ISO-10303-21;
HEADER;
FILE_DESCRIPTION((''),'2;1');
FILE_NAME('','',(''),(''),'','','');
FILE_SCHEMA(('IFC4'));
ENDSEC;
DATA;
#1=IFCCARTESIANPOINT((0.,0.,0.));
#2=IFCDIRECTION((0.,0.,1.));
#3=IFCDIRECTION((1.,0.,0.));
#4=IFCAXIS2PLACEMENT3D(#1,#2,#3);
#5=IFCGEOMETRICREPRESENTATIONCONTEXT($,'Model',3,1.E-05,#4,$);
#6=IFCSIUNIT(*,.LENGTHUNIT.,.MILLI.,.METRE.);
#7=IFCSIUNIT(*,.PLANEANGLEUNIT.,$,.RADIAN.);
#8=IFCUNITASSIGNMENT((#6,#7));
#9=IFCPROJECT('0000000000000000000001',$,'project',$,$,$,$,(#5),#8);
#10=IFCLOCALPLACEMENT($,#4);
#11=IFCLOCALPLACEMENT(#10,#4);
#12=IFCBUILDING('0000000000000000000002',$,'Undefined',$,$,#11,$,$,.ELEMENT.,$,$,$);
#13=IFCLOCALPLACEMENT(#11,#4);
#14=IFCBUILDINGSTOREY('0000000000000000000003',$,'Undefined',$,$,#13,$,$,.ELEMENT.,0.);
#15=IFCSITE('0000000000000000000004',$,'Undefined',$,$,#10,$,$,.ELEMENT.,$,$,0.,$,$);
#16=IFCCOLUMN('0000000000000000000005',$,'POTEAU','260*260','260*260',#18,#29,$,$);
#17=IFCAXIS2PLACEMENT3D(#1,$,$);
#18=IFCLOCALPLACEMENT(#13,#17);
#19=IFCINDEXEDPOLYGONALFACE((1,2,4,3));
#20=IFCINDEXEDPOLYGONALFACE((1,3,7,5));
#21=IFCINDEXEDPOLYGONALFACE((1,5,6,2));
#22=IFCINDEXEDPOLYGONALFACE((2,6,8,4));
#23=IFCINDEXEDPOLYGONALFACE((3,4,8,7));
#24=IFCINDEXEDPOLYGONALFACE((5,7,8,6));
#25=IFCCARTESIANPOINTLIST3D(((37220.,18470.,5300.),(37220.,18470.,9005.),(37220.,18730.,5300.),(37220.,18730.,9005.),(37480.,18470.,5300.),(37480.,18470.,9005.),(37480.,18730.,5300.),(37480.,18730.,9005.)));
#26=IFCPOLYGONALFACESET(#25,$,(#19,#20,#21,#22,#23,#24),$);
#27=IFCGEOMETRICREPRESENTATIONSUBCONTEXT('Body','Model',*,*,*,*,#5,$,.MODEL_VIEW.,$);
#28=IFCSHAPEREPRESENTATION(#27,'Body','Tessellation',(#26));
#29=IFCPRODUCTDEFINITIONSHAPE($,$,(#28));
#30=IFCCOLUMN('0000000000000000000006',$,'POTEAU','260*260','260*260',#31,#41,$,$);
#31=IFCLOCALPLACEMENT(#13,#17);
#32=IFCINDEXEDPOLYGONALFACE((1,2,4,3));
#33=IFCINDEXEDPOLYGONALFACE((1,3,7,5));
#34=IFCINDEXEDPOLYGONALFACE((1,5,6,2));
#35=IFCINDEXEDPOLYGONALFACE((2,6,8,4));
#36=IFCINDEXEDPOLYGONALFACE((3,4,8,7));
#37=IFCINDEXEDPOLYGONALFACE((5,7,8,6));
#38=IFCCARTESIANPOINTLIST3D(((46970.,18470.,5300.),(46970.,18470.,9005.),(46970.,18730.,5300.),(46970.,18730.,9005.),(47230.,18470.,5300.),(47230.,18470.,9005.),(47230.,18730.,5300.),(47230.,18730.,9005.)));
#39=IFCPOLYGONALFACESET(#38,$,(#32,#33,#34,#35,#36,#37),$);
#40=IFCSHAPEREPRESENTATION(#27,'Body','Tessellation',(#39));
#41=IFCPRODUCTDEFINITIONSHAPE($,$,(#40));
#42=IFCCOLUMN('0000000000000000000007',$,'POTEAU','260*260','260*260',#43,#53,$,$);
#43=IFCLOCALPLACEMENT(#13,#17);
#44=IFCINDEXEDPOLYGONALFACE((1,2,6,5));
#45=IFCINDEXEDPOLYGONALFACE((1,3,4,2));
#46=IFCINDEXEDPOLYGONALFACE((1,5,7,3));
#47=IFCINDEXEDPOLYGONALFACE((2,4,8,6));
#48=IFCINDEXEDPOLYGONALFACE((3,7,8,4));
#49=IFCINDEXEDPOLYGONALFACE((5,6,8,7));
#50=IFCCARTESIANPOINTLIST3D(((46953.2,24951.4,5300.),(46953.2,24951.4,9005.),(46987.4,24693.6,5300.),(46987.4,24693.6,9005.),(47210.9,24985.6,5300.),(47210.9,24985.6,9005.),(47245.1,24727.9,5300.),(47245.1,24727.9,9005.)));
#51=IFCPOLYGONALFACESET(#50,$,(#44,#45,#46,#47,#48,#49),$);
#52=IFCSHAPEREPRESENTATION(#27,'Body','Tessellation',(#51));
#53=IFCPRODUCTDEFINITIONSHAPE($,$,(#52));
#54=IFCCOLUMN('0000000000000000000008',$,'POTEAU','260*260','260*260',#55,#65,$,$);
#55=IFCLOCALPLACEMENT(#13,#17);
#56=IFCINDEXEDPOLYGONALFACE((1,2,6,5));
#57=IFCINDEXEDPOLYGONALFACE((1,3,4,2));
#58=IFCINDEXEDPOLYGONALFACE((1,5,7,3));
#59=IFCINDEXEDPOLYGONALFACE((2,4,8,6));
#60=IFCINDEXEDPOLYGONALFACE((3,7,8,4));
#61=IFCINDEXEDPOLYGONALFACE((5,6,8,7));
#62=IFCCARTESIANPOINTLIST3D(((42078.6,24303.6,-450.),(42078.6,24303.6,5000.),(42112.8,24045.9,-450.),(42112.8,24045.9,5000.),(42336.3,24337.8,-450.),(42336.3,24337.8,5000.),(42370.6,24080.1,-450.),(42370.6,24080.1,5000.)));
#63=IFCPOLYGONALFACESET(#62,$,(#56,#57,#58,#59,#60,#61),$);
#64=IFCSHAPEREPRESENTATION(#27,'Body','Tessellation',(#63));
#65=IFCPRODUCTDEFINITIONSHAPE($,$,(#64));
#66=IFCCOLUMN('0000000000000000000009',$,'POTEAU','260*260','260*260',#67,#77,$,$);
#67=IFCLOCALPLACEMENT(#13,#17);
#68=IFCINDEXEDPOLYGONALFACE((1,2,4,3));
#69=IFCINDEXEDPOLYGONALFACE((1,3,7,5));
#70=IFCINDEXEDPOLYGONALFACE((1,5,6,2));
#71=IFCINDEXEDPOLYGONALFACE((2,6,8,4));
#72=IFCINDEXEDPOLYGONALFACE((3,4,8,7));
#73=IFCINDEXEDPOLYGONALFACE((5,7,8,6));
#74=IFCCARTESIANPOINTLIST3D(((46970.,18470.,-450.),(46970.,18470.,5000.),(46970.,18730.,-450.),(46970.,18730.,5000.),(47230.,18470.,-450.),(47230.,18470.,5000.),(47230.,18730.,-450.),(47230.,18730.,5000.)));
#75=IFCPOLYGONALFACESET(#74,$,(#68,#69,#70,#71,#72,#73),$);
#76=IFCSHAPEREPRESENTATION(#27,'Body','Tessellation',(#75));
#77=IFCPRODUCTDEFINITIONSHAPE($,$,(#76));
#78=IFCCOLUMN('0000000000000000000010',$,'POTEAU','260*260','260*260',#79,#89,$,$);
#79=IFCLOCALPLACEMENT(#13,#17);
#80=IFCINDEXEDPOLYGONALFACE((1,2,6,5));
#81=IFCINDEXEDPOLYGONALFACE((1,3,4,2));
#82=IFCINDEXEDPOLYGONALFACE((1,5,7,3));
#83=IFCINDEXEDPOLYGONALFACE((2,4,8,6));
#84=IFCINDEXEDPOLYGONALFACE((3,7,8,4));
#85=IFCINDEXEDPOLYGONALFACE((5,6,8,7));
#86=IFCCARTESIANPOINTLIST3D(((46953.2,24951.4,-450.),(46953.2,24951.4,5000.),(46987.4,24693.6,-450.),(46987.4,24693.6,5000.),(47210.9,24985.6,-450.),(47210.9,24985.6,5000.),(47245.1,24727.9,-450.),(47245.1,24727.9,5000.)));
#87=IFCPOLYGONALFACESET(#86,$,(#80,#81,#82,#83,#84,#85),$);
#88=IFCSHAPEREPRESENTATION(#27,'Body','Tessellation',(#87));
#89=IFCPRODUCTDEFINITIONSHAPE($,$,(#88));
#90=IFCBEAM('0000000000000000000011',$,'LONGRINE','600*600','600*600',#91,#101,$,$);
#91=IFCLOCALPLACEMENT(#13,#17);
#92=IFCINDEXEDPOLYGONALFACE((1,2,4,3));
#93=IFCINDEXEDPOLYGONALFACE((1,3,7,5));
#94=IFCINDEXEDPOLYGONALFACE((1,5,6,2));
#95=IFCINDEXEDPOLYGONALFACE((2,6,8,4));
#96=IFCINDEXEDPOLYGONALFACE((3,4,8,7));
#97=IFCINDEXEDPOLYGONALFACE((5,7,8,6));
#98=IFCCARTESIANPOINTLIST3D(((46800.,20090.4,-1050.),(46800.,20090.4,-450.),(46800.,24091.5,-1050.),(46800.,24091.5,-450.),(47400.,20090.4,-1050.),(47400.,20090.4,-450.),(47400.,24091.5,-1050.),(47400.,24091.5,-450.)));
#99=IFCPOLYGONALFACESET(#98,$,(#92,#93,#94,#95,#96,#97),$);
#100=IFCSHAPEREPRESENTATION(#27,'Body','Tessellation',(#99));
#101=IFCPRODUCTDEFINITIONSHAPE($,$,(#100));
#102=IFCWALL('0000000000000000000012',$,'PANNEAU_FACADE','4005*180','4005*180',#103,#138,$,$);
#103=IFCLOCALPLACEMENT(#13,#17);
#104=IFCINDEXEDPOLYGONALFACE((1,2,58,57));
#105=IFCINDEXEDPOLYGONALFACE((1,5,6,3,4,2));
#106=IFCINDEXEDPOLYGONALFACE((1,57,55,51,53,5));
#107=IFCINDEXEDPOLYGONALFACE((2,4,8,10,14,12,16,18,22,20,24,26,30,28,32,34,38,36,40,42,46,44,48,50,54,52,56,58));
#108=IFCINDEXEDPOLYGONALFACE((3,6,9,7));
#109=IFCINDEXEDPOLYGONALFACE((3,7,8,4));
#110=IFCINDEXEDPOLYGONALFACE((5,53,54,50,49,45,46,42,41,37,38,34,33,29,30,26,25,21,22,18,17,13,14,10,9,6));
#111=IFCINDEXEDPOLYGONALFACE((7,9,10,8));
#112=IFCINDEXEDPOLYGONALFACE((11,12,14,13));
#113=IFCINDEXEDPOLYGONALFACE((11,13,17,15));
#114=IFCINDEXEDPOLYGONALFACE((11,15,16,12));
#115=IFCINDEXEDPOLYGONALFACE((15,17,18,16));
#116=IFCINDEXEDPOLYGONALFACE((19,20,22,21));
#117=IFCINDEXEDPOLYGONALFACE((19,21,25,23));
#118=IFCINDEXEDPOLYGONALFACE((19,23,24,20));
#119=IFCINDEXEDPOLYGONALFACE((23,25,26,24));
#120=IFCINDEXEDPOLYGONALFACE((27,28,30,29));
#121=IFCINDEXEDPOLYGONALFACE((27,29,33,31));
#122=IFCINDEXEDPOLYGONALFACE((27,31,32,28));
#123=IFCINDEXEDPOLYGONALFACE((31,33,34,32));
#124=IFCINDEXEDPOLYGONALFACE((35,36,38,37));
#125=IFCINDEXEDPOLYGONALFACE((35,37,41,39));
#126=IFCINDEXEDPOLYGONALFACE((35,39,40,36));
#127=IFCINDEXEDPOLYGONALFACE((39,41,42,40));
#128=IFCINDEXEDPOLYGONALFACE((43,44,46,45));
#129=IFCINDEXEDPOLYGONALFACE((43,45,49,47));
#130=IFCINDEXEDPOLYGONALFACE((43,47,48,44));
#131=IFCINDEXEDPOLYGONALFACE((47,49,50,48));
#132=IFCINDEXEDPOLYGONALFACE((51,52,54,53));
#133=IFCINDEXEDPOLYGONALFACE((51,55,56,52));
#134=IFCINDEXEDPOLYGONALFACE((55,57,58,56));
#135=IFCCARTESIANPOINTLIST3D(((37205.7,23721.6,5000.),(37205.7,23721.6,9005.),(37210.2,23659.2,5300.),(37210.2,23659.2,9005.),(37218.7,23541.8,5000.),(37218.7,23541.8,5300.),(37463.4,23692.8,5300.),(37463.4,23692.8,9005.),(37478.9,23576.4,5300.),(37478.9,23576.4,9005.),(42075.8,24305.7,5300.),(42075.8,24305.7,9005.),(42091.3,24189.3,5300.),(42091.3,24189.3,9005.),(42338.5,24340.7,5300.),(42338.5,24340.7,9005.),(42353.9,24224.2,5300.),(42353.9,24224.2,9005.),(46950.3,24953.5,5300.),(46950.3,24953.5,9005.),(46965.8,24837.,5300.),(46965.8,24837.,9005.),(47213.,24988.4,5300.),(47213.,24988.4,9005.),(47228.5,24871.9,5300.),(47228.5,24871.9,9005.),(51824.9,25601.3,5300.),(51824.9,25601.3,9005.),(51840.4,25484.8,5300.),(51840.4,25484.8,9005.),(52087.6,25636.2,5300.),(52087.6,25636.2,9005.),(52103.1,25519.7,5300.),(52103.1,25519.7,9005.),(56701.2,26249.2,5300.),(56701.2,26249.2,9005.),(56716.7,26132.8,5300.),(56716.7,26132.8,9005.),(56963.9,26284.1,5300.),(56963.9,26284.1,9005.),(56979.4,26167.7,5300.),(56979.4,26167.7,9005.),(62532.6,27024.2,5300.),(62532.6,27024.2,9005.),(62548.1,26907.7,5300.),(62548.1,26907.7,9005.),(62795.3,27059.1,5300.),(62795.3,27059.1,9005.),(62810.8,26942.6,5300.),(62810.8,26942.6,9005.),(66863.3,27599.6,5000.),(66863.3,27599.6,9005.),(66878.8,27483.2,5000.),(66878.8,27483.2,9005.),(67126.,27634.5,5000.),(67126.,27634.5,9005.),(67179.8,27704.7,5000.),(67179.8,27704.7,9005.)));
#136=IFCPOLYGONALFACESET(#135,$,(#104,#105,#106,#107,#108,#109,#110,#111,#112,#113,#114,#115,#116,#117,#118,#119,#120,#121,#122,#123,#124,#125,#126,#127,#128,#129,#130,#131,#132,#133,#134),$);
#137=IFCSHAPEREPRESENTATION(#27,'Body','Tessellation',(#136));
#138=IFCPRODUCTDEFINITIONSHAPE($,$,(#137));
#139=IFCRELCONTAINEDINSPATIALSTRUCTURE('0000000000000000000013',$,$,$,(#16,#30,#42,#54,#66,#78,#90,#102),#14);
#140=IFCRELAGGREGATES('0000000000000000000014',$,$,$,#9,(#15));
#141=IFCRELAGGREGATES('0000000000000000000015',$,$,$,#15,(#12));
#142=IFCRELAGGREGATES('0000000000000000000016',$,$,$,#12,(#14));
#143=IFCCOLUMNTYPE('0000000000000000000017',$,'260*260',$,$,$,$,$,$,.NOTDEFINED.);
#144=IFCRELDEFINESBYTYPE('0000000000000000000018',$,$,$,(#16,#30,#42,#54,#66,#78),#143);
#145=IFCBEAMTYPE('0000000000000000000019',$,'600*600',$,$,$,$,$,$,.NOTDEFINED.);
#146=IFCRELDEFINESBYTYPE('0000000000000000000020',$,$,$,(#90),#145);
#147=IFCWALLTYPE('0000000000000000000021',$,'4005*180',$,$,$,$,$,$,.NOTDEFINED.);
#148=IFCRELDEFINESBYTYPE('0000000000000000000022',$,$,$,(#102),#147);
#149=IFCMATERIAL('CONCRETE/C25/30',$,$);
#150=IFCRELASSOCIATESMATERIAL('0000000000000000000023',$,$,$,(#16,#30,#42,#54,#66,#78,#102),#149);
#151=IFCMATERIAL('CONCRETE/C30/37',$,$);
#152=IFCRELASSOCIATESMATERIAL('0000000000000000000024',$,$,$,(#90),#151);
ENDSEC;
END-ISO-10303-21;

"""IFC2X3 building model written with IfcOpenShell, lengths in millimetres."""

from ifc_helpers import new_model, si_unit, frame, frame_2d, origin_with_axes, origin_2d_with_axis, place, context, subcontext, project, spatial, rectangle, extrude, boolean, halfspace, material, type_object, element, save


model = new_model("IFC2X3")

# Units and contexts
model_context = context("Model", 3, precision=1e-05, world=origin_with_axes())
body_context = subcontext(model_context, "Body", "Model", "MODEL_VIEW")
ifc_project = project(units=[si_unit("LENGTHUNIT", "METRE", prefix="MILLI"), si_unit("PLANEANGLEUNIT", "RADIAN")], contexts=[model_context])

# Site, building, storey
site_placement = place(None, origin_with_axes())
site = spatial("IfcSite", under=ifc_project, at=site_placement, Name="Undefined", CompositionType="ELEMENT", RefElevation=0.0)
building_placement = place(site_placement, origin_with_axes())
building = spatial("IfcBuilding", under=site, at=building_placement, Name="Undefined", CompositionType="ELEMENT")
storey_placement = place(building_placement, origin_with_axes())
storey = spatial("IfcBuildingStorey", under=building, at=storey_placement, Name="Undefined", CompositionType="ELEMENT", Elevation=0.0)

# Columns
ifc_material_1 = material(Name="CONCRETE/C30/37")
ifc_material_2 = material(Name="CONCRETE/C25/30")
column_type_1 = type_object("IfcColumnType", Name="260*260", PredefinedType="NOTDEFINED")
for number, where, z_axis, x_axis, name in (
    (1, (37350.0, 18600.0, 5300.0), (0.0, 0.0, 1.0), (1.0, 0.0, 0.0), "POTEAU"),
    (2, (47100.0, 18600.0, 5300.0), (0.0, 0.0, 1.0), (1.0, 0.0, 0.0), "POTEAU"),
):
    element("IfcColumn", number, at=place(storey_placement, frame(where, z_axis=z_axis, x_axis=x_axis)), inside=storey, type_object=column_type_1, material=ifc_material_2, Name=name, Description="260*260", ObjectType="260*260", context=body_context, shape_type="SweptSolid", body=[
        extrude(rectangle(XDim=260.0, YDim=260.0, at=origin_2d_with_axis()), frame((0.0, 0.0, 3705.0), z_axis=(0.0, 0.0, -1.0), x_axis=(-1.0, 0.0, 0.0)), (0.0, 0.0, 1.0), 3705.0),
    ])
column_1_placement = place(storey_placement, frame((47099.1, 24839.6, 5300.0), z_axis=(0.0, 0.0, 1.0), x_axis=(1.0, 0.0, 0.0)))
element("IfcColumn", 3, at=column_1_placement, inside=storey, type_object=column_type_1, material=ifc_material_2, Name="POTEAU", Description="260*260", ObjectType="260*260", context=body_context, shape_type="SweptSolid", body=[
    extrude(rectangle(XDim=260.0, YDim=260.0, at=origin_2d_with_axis()), frame((0.0, 0.0, 3705.0), z_axis=(0.0, 0.0, -1.0), x_axis=(-0.131727, 0.991286, 0.0)), (0.0, 0.0, 1.0), 3705.0),
])
column_2_placement = place(storey_placement, frame((42224.6, 24191.9, -450.0), z_axis=(0.0, 0.0, 1.0), x_axis=(1.0, 0.0, 0.0)))
element("IfcColumn", 4, at=column_2_placement, inside=storey, type_object=column_type_1, material=ifc_material_2, Name="POTEAU", Description="260*260", ObjectType="260*260", context=body_context, shape_type="SweptSolid", body=[
    extrude(rectangle(XDim=260.0, YDim=260.0, at=origin_2d_with_axis()), frame((0.0, 0.0, 5450.0), z_axis=(0.0, 0.0, -1.0), x_axis=(-0.131727, 0.991286, 0.0)), (0.0, 0.0, 1.0), 5450.0),
])
column_3_placement = place(storey_placement, frame((47100.0, 18600.0, -450.0), z_axis=(0.0, 0.0, 1.0), x_axis=(1.0, 0.0, 0.0)))
element("IfcColumn", 5, at=column_3_placement, inside=storey, type_object=column_type_1, material=ifc_material_2, Name="POTEAU", Description="260*260", ObjectType="260*260", context=body_context, shape_type="SweptSolid", body=[
    extrude(rectangle(XDim=260.0, YDim=260.0, at=origin_2d_with_axis()), frame((0.0, 0.0, 5450.0), z_axis=(0.0, 0.0, -1.0), x_axis=(-1.0, 0.0, 0.0)), (0.0, 0.0, 1.0), 5450.0),
])
column_4_placement = place(storey_placement, frame((47099.1, 24839.6, -450.0), z_axis=(0.0, 0.0, 1.0), x_axis=(1.0, 0.0, 0.0)))
element("IfcColumn", 6, at=column_4_placement, inside=storey, type_object=column_type_1, material=ifc_material_2, Name="POTEAU", Description="260*260", ObjectType="260*260", context=body_context, shape_type="SweptSolid", body=[
    extrude(rectangle(XDim=260.0, YDim=260.0, at=origin_2d_with_axis()), frame((0.0, 0.0, 5450.0), z_axis=(0.0, 0.0, -1.0), x_axis=(-0.131727, 0.991286, 0.0)), (0.0, 0.0, 1.0), 5450.0),
])

# Beam
beam_type_1 = type_object("IfcBeamType", Name="600*600", PredefinedType="NOTDEFINED")
beam_1_placement = place(storey_placement, frame((47100.0, 20090.4, -750.0), z_axis=(0.0, 0.0, 1.0), x_axis=(0.0, 1.0, 0.0)))
element("IfcBeam", 7, at=beam_1_placement, inside=storey, type_object=beam_type_1, material=ifc_material_1, Name="LONGRINE", Description="600*600", ObjectType="600*600", context=body_context, shape_type="SweptSolid", body=[
    extrude(rectangle(XDim=600.0, YDim=600.0, at=origin_2d_with_axis()), frame((4001.1, 0.0, 0.0), z_axis=(-1.0, 0.0, 0.0), x_axis=(0.0, -1.0, 0.0)), (0.0, 0.0, 1.0), 4001.1),
])

# Wall
wall_type_1 = type_object("IfcWallType", Name="4005*180", PredefinedType="NOTDEFINED")
wall_1_placement = place(storey_placement, frame((37206.8, 23631.0, 5000.0), z_axis=(0.0, 0.0, 1.0), x_axis=(0.991286, 0.131727, 0.0)))
solid_1 = boolean("DIFFERENCE", boolean("DIFFERENCE", boolean("DIFFERENCE", boolean("DIFFERENCE", boolean("DIFFERENCE", boolean("DIFFERENCE", boolean("DIFFERENCE", boolean("DIFFERENCE", extrude(rectangle(XDim=30629.4, YDim=180.0, at=frame_2d((0.0, 15081.9), x_axis=(0.0, -1.0))), frame((0.0, 0.0, 0.0), z_axis=(0.0, 0.0, 1.0), x_axis=(0.0, -1.0, 0.0)), (0.0, 0.0, 1.0), 4005.0), extrude(rectangle(XDim=265.0, YDim=265.0, at=origin_2d_with_axis()), frame((30053.4, -105.0, 4005.0), z_axis=(0.0, 0.0, -1.0), x_axis=(0.0, 1.0, 0.0)), (0.0, 0.0, 1.0), 4005.0)), extrude(rectangle(XDim=265.0, YDim=265.0, at=origin_2d_with_axis()), frame((25684.6, -105.0, 4005.0), z_axis=(0.0, 0.0, -1.0), x_axis=(0.0, 1.0, 0.0)), (0.0, 0.0, 1.0), 3705.0)), extrude(rectangle(XDim=265.0, YDim=265.0, at=origin_2d_with_axis()), frame((19801.9, -105.0, 4005.0), z_axis=(0.0, 0.0, -1.0), x_axis=(0.0, 1.0, 0.0)), (0.0, 0.0, 1.0), 3705.0)), extrude(rectangle(XDim=265.0, YDim=265.0, at=origin_2d_with_axis()), frame((14882.8, -105.0, 4005.0), z_axis=(0.0, 0.0, -1.0), x_axis=(0.0, 1.0, 0.0)), (0.0, 0.0, 1.0), 3705.0)), extrude(rectangle(XDim=265.0, YDim=265.0, at=origin_2d_with_axis()), frame((9965.3, -105.0, 4005.0), z_axis=(0.0, 0.0, -1.0), x_axis=(0.0, 1.0, 0.0)), (0.0, 0.0, 1.0), 3705.0)), extrude(rectangle(XDim=265.0, YDim=265.0, at=origin_2d_with_axis()), frame((5047.9, -105.0, 4005.0), z_axis=(0.0, 0.0, -1.0), x_axis=(0.0, 1.0, 0.0)), (0.0, 0.0, 1.0), 3705.0)), extrude(rectangle(XDim=265.0, YDim=265.0, at=origin_2d_with_axis()), frame((130.0, -105.0, 4005.0), z_axis=(0.0, 0.0, -1.0), x_axis=(0.0, 1.0, 0.0)), (0.0, 0.0, 1.0), 3705.0)), halfspace(frame((30248.4, 90.0, 2002.5), z_axis=(-0.706948, 0.707265, 0.0), x_axis=(0.0, 0.0, 1.0)), True))
element("IfcWall", 8, at=wall_1_placement, inside=storey, type_object=wall_type_1, material=ifc_material_2, Name="PANNEAU_FACADE", Description="4005*180", ObjectType="4005*180", context=body_context, shape_type="CSG", body=[
    boolean("DIFFERENCE", solid_1, halfspace(frame((10.9, 90.0, 2002.5), z_axis=(-0.998181, 0.060293, 0.0), x_axis=(0.0, 0.0, 1.0)), False)),
])

save(model, "model.ifc")
